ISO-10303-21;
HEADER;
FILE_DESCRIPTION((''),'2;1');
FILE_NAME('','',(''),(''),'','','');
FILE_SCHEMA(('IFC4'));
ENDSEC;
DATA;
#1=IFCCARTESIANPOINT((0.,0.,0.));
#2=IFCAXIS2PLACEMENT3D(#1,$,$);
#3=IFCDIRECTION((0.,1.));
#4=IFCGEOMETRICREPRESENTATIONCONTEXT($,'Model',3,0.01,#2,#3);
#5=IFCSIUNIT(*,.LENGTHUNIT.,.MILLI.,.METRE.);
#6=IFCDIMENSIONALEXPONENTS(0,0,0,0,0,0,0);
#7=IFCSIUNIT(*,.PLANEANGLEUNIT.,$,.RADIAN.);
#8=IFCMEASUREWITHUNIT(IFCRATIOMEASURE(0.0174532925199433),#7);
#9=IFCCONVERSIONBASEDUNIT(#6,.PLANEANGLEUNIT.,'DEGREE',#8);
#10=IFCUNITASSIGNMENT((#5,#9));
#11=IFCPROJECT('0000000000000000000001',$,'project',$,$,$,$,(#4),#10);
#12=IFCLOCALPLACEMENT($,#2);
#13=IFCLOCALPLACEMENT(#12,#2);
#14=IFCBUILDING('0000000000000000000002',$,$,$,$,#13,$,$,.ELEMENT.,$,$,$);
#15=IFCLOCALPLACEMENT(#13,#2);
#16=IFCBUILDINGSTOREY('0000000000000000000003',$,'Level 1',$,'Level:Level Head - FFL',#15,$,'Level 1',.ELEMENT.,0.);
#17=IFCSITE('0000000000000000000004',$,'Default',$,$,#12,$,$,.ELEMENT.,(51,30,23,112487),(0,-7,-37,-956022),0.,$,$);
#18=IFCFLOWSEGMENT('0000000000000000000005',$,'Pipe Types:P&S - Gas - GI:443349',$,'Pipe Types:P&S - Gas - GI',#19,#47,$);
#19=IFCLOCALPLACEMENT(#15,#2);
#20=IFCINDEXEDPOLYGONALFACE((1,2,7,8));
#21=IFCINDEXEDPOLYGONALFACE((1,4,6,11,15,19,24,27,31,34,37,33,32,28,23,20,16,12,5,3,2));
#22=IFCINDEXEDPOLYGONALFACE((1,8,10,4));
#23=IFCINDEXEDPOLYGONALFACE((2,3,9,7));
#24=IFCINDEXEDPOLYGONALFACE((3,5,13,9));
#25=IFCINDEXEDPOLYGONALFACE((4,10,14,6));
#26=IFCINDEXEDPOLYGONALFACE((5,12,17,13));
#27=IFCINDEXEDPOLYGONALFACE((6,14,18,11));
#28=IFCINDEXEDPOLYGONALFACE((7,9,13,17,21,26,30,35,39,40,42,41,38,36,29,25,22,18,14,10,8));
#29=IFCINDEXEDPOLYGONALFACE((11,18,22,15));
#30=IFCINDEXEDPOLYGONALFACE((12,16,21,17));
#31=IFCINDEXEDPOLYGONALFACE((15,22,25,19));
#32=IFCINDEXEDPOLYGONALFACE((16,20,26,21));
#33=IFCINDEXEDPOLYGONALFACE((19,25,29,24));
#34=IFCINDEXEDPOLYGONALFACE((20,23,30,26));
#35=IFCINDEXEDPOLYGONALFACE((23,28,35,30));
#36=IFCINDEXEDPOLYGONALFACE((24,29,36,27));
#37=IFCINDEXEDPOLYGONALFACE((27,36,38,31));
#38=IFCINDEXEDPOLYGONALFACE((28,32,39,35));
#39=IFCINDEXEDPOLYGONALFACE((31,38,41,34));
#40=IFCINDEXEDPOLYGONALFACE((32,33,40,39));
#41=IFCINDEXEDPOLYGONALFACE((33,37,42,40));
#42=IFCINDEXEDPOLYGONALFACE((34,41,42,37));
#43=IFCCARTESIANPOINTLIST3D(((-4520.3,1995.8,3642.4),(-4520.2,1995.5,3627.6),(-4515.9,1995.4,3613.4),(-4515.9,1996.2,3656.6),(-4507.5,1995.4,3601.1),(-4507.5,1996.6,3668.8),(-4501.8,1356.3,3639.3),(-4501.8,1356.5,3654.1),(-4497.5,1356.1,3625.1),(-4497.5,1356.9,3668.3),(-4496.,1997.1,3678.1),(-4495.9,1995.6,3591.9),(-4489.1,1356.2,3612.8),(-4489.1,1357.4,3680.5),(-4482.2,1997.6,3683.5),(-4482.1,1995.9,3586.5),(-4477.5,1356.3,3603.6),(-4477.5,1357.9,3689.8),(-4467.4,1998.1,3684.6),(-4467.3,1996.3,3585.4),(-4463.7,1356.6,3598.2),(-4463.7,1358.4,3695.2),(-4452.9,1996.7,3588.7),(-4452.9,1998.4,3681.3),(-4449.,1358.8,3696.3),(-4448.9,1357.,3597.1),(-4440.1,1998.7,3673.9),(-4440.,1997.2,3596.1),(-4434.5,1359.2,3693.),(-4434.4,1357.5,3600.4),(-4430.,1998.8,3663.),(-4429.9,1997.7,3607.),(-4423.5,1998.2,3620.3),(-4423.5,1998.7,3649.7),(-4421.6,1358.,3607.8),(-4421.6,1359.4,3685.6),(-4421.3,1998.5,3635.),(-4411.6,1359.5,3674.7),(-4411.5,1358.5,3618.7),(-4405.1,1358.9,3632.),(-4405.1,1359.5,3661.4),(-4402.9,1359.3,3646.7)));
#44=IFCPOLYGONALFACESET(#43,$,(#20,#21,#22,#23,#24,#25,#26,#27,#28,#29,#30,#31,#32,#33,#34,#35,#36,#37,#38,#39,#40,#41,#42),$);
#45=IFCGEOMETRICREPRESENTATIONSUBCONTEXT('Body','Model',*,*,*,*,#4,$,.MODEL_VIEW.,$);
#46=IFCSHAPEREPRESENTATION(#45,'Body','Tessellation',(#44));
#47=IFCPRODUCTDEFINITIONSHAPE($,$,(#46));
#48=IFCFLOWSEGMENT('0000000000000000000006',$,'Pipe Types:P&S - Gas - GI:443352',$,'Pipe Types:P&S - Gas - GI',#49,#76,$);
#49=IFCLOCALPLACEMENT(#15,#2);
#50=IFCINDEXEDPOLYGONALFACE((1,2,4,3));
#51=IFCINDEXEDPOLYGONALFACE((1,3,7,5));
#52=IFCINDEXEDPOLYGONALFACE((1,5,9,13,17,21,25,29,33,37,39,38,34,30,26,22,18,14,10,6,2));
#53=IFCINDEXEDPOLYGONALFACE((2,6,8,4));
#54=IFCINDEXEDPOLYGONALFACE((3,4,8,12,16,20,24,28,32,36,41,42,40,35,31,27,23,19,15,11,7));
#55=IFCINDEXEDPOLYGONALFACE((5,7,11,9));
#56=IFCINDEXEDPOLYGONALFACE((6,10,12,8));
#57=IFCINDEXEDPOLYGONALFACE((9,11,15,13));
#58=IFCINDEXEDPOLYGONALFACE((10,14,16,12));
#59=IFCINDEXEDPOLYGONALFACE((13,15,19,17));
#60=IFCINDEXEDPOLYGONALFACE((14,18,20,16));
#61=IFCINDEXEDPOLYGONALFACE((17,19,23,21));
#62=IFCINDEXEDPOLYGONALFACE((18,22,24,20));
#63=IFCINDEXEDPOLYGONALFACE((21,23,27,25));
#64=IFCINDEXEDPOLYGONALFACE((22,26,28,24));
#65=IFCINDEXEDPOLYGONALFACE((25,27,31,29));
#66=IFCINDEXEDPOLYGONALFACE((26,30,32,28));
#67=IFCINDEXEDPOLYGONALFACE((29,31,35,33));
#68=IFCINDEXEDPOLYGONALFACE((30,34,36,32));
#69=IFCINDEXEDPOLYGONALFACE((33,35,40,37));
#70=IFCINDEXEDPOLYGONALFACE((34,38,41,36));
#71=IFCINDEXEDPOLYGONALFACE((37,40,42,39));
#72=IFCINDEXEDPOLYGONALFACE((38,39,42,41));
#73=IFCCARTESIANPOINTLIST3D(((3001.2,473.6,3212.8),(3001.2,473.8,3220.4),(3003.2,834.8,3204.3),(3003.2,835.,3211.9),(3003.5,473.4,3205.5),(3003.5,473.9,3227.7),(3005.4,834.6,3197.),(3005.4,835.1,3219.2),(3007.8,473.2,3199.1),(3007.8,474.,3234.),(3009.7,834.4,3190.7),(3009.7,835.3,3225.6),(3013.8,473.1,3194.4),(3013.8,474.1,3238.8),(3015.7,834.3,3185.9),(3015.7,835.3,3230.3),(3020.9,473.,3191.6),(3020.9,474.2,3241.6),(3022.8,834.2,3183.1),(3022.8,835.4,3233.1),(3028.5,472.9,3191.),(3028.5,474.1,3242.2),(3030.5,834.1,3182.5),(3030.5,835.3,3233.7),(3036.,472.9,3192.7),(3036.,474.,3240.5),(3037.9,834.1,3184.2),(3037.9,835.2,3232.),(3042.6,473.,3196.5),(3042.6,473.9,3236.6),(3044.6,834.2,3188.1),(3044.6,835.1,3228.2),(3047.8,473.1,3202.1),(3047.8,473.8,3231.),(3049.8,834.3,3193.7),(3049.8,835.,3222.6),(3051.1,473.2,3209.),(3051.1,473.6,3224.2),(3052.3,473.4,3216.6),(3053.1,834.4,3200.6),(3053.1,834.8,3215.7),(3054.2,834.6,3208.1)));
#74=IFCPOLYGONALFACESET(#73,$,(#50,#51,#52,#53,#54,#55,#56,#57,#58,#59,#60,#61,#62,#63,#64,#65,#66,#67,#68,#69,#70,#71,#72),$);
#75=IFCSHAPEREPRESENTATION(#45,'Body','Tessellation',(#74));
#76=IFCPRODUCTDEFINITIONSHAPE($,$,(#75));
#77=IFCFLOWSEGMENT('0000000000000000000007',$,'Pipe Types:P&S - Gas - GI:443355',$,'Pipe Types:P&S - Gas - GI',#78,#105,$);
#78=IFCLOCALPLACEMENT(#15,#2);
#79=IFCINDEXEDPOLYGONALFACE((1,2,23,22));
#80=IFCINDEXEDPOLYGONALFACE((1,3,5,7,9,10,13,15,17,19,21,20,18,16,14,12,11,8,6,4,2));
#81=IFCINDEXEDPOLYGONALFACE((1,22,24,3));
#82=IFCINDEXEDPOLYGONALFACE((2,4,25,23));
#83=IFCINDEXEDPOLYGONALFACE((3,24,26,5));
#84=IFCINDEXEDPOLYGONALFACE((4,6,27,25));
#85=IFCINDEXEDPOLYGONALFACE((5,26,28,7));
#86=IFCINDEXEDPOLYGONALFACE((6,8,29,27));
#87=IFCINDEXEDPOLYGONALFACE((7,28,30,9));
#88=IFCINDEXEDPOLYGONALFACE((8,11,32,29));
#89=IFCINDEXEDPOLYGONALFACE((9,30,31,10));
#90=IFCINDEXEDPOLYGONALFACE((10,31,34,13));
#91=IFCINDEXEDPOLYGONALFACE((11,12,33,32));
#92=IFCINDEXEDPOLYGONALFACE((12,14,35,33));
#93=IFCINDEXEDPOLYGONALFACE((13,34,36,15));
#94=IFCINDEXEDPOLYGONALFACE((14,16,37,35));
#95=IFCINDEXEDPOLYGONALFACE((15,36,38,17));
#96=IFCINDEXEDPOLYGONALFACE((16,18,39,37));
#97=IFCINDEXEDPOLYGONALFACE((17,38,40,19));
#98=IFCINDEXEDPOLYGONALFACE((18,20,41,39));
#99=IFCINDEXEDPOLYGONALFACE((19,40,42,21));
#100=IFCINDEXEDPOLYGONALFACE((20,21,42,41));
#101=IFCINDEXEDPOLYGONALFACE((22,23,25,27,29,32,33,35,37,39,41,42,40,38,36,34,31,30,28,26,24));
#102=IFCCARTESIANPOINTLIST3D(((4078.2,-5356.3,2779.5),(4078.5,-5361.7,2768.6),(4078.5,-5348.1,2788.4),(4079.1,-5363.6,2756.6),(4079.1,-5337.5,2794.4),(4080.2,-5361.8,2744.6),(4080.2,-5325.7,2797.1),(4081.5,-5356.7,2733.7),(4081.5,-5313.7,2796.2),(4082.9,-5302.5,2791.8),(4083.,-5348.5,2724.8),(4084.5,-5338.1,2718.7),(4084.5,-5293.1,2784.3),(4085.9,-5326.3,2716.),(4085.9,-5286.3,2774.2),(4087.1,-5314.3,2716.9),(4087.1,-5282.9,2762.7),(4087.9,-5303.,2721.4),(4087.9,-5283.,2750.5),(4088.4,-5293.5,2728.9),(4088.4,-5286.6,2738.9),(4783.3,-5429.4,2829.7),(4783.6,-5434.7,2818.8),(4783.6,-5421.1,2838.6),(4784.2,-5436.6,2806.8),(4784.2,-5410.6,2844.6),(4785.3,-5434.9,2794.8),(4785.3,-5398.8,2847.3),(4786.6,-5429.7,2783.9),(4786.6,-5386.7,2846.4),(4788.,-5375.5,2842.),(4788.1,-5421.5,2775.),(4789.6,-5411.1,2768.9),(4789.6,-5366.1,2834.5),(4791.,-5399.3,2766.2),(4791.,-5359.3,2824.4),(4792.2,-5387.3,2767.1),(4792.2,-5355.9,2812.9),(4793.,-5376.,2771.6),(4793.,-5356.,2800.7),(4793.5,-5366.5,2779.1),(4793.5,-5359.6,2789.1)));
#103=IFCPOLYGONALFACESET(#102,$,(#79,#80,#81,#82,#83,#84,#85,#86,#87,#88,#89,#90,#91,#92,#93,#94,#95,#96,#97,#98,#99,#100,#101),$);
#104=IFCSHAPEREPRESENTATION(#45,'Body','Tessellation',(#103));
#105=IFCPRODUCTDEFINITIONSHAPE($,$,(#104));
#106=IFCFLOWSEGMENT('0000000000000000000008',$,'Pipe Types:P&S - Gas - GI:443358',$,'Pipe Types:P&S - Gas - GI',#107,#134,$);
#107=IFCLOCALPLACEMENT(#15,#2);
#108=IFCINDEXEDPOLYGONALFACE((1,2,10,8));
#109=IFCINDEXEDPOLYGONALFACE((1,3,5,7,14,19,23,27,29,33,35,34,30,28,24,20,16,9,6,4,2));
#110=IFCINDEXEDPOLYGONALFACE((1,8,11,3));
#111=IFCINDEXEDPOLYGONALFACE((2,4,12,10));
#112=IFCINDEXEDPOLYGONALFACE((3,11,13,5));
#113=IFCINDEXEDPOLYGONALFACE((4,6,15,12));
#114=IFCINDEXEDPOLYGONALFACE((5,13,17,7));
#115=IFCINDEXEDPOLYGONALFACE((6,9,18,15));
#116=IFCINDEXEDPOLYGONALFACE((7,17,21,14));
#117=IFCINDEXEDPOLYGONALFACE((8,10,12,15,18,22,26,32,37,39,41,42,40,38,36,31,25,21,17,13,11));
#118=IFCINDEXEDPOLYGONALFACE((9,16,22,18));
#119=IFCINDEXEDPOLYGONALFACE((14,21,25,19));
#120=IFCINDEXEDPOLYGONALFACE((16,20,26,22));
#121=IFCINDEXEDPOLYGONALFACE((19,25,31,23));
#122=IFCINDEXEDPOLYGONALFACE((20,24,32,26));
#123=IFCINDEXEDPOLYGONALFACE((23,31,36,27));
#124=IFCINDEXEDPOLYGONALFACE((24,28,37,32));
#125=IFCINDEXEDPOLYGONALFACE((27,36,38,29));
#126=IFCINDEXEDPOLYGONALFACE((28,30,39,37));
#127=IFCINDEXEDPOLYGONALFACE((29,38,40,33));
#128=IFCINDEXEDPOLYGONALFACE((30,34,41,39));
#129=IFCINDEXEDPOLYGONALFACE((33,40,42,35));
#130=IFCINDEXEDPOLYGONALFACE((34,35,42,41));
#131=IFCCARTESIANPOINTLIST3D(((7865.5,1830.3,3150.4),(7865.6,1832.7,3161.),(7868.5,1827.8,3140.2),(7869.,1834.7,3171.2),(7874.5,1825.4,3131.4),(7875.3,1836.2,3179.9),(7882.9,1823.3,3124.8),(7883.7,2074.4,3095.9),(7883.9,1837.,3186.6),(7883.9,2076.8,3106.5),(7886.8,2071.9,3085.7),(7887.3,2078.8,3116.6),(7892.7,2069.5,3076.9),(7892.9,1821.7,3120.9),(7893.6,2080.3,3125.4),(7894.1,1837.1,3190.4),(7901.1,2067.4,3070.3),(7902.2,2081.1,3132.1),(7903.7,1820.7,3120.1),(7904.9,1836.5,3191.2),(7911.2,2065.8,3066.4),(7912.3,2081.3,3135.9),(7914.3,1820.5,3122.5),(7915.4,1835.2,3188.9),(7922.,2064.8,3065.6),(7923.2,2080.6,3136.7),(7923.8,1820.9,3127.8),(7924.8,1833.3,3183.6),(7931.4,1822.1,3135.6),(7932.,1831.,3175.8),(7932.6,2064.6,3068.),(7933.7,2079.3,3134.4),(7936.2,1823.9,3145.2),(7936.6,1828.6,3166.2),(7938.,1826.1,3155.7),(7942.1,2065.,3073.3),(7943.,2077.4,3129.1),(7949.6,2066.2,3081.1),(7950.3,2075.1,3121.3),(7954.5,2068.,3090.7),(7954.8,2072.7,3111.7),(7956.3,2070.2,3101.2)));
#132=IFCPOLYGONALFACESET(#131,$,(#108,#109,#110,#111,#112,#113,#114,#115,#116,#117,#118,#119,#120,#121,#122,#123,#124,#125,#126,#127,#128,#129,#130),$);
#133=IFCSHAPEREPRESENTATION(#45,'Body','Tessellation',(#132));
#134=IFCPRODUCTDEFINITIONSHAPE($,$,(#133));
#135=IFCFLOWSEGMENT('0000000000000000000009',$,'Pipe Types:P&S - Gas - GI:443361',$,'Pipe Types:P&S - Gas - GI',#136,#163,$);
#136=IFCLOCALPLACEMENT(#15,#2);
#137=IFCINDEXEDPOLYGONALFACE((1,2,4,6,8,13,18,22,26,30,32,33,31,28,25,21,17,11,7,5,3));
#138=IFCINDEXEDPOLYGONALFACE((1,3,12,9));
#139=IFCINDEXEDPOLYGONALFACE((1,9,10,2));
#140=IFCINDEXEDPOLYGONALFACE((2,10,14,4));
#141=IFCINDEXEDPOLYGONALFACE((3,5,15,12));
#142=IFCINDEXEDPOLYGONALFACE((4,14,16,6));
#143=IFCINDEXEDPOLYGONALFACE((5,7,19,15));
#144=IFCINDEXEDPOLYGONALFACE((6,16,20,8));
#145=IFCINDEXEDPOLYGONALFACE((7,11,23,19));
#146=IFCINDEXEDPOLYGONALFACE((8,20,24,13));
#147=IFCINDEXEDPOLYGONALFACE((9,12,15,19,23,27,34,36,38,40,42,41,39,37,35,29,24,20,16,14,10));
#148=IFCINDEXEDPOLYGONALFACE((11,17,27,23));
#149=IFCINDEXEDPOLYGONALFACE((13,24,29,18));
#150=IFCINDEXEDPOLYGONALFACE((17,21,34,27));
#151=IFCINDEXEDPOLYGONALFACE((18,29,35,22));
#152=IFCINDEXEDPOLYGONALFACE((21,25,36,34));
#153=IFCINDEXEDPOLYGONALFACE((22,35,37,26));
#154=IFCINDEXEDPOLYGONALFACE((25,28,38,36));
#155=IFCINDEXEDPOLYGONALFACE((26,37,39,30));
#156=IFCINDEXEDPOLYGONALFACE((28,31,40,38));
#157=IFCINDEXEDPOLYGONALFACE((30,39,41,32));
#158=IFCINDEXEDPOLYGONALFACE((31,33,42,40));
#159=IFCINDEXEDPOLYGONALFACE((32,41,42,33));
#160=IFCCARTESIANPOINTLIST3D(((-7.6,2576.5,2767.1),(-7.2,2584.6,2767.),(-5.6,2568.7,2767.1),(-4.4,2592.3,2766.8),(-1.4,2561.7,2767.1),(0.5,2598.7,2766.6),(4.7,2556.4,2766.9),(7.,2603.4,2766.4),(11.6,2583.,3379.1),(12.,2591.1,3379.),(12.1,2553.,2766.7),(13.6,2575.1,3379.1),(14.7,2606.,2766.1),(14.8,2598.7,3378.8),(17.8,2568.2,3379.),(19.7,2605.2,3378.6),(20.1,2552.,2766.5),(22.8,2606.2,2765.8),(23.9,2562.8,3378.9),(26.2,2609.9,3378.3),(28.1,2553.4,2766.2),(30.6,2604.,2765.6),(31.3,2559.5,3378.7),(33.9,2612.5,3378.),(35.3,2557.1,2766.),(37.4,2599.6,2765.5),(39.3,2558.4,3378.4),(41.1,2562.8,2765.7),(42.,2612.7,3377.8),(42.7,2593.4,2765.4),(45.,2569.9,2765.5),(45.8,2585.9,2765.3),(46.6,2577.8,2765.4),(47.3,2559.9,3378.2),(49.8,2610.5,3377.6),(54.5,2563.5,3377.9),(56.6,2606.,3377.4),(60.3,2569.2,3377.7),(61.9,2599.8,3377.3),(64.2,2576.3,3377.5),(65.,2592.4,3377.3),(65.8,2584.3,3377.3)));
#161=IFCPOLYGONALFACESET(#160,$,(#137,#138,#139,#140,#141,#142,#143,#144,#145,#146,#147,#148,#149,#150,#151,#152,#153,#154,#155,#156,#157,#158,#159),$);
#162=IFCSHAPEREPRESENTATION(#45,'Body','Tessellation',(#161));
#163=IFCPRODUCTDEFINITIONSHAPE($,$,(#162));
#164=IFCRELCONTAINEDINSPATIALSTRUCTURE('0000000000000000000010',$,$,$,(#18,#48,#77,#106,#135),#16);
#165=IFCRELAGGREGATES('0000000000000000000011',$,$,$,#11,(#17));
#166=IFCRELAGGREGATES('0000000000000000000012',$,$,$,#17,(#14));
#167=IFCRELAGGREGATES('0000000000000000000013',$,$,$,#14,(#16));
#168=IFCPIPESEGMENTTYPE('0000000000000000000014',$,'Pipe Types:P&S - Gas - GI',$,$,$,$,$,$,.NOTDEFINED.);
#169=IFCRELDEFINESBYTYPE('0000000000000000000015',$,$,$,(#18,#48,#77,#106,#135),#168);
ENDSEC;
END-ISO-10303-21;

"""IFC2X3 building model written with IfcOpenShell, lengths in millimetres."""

from ifc_helpers import new_model, entity, si_unit, converted_unit, direction, frame, frame_2d, origin, origin_2d_with_axis, place, context, subcontext, project, spatial, circle, extrude, type_object, element, save


model = new_model("IFC2X3")

# Units and contexts
model_context = context("Model", 3, precision=0.01, world=origin(), true_north=direction((0.0, 1.0)))
body_context = subcontext(model_context, "Body", "Model", "MODEL_VIEW")
ifc_project = project(units=[si_unit("LENGTHUNIT", "METRE", prefix="MILLI"), converted_unit("PLANEANGLEUNIT", "DEGREE", entity("IfcRatioMeasure", 0.0174532925199433), si_unit("PLANEANGLEUNIT", "RADIAN"), dimensions=[0, 0, 0, 0, 0, 0, 0])], contexts=[model_context])

# Site, building, storey
site_placement = place(None, origin())
site = spatial("IfcSite", under=ifc_project, at=site_placement, Name="Default", CompositionType="ELEMENT", RefLatitude=(51, 30, 23, 112487), RefLongitude=(0, -7, -37, -956022), RefElevation=0.0)
building_placement = place(site_placement, origin())
building = spatial("IfcBuilding", under=site, at=building_placement, CompositionType="ELEMENT")
storey_placement = place(building_placement, origin())
storey = spatial("IfcBuildingStorey", under=building, at=storey_placement, Name="Level 1", ObjectType="Level:Level Head - FFL", LongName="Level 1", CompositionType="ELEMENT", Elevation=0.0)

# Flow segments
pipe_segment_type = type_object("IfcPipeSegmentType", Name="Pipe Types:P&S - Gas - GI", PredefinedType="NOTDEFINED")
flow_segment_1_placement = place(storey_placement, origin())
element("IfcFlowSegment", 1, at=flow_segment_1_placement, inside=storey, type_object=pipe_segment_type, Name="Pipe Types:P&S - Gas - GI:443349", ObjectType="Pipe Types:P&S - Gas - GI", context=body_context, shape_type="SweptSolid", body=[
    extrude(circle(Radius=49.8, at=origin_2d_with_axis()), frame((-4471.1, 1997.1, 3635.0), z_axis=(0.028783, -0.999418, 0.018291), x_axis=(0.999586, 0.028788, 0.0)), (0.0, 0.0, 1.0), 639.6),
])
flow_segment_2_placement = place(storey_placement, origin())
element("IfcFlowSegment", 2, at=flow_segment_2_placement, inside=storey, type_object=pipe_segment_type, Name="Pipe Types:P&S - Gas - GI:443352", ObjectType="Pipe Types:P&S - Gas - GI", context=body_context, shape_type="SweptSolid", body=[
    extrude(circle(Radius=25.7, at=frame_2d((0.0, 0.0), x_axis=(1.0, 0.0))), frame((3028.6, 834.7, 3208.1), z_axis=(-0.005436, -0.99971, 0.023456), x_axis=(0.999985, -0.005437, 0.0)), (0.0, 0.0, 1.0), 361.3),
])
flow_segment_3_placement = place(storey_placement, origin())
element("IfcFlowSegment", 3, at=flow_segment_3_placement, inside=storey, type_object=pipe_segment_type, Name="Pipe Types:P&S - Gas - GI:443355", ObjectType="Pipe Types:P&S - Gas - GI", context=body_context, shape_type="SweptSolid", body=[
    extrude(circle(Radius=40.8, at=origin_2d_with_axis()), frame((4083.3, -5323.0, 2756.6), z_axis=(0.992197, -0.102737, 0.070637), x_axis=(-0.102994, -0.994682, 0.0)), (0.0, 0.0, 1.0), 710.6),
])
flow_segment_4_placement = place(storey_placement, origin())
element("IfcFlowSegment", 4, at=flow_segment_4_placement, inside=storey, type_object=pipe_segment_type, Name="Pipe Types:P&S - Gas - GI:443358", ObjectType="Pipe Types:P&S - Gas - GI", context=body_context, shape_type="SweptSolid", body=[
    extrude(circle(Radius=36.5, at=frame_2d((0.0, 0.0), x_axis=(1.0, 0.0))), frame((7901.6, 1828.8, 3155.7), z_axis=(0.072855, 0.973368, -0.217365), x_axis=(0.997211, -0.074639, 0.0)), (0.0, 0.0, 1.0), 250.8),
])
flow_segment_5_placement = place(storey_placement, origin())
element("IfcFlowSegment", 5, at=flow_segment_5_placement, inside=storey, type_object=pipe_segment_type, Name="Pipe Types:P&S - Gas - GI:443361", ObjectType="Pipe Types:P&S - Gas - GI", context=body_context, shape_type="SweptSolid", body=[
    extrude(circle(Radius=27.2, at=frame_2d((0.0, 0.0), x_axis=(1.0, 0.0))), frame((19.4, 2579.2, 2766.2), z_axis=(0.031356, 0.010514, 0.999453), x_axis=(0.317925, -0.948116, 0.0)), (0.0, 0.0, 1.0), 612.3),
])

save(model, "model.ifc")
